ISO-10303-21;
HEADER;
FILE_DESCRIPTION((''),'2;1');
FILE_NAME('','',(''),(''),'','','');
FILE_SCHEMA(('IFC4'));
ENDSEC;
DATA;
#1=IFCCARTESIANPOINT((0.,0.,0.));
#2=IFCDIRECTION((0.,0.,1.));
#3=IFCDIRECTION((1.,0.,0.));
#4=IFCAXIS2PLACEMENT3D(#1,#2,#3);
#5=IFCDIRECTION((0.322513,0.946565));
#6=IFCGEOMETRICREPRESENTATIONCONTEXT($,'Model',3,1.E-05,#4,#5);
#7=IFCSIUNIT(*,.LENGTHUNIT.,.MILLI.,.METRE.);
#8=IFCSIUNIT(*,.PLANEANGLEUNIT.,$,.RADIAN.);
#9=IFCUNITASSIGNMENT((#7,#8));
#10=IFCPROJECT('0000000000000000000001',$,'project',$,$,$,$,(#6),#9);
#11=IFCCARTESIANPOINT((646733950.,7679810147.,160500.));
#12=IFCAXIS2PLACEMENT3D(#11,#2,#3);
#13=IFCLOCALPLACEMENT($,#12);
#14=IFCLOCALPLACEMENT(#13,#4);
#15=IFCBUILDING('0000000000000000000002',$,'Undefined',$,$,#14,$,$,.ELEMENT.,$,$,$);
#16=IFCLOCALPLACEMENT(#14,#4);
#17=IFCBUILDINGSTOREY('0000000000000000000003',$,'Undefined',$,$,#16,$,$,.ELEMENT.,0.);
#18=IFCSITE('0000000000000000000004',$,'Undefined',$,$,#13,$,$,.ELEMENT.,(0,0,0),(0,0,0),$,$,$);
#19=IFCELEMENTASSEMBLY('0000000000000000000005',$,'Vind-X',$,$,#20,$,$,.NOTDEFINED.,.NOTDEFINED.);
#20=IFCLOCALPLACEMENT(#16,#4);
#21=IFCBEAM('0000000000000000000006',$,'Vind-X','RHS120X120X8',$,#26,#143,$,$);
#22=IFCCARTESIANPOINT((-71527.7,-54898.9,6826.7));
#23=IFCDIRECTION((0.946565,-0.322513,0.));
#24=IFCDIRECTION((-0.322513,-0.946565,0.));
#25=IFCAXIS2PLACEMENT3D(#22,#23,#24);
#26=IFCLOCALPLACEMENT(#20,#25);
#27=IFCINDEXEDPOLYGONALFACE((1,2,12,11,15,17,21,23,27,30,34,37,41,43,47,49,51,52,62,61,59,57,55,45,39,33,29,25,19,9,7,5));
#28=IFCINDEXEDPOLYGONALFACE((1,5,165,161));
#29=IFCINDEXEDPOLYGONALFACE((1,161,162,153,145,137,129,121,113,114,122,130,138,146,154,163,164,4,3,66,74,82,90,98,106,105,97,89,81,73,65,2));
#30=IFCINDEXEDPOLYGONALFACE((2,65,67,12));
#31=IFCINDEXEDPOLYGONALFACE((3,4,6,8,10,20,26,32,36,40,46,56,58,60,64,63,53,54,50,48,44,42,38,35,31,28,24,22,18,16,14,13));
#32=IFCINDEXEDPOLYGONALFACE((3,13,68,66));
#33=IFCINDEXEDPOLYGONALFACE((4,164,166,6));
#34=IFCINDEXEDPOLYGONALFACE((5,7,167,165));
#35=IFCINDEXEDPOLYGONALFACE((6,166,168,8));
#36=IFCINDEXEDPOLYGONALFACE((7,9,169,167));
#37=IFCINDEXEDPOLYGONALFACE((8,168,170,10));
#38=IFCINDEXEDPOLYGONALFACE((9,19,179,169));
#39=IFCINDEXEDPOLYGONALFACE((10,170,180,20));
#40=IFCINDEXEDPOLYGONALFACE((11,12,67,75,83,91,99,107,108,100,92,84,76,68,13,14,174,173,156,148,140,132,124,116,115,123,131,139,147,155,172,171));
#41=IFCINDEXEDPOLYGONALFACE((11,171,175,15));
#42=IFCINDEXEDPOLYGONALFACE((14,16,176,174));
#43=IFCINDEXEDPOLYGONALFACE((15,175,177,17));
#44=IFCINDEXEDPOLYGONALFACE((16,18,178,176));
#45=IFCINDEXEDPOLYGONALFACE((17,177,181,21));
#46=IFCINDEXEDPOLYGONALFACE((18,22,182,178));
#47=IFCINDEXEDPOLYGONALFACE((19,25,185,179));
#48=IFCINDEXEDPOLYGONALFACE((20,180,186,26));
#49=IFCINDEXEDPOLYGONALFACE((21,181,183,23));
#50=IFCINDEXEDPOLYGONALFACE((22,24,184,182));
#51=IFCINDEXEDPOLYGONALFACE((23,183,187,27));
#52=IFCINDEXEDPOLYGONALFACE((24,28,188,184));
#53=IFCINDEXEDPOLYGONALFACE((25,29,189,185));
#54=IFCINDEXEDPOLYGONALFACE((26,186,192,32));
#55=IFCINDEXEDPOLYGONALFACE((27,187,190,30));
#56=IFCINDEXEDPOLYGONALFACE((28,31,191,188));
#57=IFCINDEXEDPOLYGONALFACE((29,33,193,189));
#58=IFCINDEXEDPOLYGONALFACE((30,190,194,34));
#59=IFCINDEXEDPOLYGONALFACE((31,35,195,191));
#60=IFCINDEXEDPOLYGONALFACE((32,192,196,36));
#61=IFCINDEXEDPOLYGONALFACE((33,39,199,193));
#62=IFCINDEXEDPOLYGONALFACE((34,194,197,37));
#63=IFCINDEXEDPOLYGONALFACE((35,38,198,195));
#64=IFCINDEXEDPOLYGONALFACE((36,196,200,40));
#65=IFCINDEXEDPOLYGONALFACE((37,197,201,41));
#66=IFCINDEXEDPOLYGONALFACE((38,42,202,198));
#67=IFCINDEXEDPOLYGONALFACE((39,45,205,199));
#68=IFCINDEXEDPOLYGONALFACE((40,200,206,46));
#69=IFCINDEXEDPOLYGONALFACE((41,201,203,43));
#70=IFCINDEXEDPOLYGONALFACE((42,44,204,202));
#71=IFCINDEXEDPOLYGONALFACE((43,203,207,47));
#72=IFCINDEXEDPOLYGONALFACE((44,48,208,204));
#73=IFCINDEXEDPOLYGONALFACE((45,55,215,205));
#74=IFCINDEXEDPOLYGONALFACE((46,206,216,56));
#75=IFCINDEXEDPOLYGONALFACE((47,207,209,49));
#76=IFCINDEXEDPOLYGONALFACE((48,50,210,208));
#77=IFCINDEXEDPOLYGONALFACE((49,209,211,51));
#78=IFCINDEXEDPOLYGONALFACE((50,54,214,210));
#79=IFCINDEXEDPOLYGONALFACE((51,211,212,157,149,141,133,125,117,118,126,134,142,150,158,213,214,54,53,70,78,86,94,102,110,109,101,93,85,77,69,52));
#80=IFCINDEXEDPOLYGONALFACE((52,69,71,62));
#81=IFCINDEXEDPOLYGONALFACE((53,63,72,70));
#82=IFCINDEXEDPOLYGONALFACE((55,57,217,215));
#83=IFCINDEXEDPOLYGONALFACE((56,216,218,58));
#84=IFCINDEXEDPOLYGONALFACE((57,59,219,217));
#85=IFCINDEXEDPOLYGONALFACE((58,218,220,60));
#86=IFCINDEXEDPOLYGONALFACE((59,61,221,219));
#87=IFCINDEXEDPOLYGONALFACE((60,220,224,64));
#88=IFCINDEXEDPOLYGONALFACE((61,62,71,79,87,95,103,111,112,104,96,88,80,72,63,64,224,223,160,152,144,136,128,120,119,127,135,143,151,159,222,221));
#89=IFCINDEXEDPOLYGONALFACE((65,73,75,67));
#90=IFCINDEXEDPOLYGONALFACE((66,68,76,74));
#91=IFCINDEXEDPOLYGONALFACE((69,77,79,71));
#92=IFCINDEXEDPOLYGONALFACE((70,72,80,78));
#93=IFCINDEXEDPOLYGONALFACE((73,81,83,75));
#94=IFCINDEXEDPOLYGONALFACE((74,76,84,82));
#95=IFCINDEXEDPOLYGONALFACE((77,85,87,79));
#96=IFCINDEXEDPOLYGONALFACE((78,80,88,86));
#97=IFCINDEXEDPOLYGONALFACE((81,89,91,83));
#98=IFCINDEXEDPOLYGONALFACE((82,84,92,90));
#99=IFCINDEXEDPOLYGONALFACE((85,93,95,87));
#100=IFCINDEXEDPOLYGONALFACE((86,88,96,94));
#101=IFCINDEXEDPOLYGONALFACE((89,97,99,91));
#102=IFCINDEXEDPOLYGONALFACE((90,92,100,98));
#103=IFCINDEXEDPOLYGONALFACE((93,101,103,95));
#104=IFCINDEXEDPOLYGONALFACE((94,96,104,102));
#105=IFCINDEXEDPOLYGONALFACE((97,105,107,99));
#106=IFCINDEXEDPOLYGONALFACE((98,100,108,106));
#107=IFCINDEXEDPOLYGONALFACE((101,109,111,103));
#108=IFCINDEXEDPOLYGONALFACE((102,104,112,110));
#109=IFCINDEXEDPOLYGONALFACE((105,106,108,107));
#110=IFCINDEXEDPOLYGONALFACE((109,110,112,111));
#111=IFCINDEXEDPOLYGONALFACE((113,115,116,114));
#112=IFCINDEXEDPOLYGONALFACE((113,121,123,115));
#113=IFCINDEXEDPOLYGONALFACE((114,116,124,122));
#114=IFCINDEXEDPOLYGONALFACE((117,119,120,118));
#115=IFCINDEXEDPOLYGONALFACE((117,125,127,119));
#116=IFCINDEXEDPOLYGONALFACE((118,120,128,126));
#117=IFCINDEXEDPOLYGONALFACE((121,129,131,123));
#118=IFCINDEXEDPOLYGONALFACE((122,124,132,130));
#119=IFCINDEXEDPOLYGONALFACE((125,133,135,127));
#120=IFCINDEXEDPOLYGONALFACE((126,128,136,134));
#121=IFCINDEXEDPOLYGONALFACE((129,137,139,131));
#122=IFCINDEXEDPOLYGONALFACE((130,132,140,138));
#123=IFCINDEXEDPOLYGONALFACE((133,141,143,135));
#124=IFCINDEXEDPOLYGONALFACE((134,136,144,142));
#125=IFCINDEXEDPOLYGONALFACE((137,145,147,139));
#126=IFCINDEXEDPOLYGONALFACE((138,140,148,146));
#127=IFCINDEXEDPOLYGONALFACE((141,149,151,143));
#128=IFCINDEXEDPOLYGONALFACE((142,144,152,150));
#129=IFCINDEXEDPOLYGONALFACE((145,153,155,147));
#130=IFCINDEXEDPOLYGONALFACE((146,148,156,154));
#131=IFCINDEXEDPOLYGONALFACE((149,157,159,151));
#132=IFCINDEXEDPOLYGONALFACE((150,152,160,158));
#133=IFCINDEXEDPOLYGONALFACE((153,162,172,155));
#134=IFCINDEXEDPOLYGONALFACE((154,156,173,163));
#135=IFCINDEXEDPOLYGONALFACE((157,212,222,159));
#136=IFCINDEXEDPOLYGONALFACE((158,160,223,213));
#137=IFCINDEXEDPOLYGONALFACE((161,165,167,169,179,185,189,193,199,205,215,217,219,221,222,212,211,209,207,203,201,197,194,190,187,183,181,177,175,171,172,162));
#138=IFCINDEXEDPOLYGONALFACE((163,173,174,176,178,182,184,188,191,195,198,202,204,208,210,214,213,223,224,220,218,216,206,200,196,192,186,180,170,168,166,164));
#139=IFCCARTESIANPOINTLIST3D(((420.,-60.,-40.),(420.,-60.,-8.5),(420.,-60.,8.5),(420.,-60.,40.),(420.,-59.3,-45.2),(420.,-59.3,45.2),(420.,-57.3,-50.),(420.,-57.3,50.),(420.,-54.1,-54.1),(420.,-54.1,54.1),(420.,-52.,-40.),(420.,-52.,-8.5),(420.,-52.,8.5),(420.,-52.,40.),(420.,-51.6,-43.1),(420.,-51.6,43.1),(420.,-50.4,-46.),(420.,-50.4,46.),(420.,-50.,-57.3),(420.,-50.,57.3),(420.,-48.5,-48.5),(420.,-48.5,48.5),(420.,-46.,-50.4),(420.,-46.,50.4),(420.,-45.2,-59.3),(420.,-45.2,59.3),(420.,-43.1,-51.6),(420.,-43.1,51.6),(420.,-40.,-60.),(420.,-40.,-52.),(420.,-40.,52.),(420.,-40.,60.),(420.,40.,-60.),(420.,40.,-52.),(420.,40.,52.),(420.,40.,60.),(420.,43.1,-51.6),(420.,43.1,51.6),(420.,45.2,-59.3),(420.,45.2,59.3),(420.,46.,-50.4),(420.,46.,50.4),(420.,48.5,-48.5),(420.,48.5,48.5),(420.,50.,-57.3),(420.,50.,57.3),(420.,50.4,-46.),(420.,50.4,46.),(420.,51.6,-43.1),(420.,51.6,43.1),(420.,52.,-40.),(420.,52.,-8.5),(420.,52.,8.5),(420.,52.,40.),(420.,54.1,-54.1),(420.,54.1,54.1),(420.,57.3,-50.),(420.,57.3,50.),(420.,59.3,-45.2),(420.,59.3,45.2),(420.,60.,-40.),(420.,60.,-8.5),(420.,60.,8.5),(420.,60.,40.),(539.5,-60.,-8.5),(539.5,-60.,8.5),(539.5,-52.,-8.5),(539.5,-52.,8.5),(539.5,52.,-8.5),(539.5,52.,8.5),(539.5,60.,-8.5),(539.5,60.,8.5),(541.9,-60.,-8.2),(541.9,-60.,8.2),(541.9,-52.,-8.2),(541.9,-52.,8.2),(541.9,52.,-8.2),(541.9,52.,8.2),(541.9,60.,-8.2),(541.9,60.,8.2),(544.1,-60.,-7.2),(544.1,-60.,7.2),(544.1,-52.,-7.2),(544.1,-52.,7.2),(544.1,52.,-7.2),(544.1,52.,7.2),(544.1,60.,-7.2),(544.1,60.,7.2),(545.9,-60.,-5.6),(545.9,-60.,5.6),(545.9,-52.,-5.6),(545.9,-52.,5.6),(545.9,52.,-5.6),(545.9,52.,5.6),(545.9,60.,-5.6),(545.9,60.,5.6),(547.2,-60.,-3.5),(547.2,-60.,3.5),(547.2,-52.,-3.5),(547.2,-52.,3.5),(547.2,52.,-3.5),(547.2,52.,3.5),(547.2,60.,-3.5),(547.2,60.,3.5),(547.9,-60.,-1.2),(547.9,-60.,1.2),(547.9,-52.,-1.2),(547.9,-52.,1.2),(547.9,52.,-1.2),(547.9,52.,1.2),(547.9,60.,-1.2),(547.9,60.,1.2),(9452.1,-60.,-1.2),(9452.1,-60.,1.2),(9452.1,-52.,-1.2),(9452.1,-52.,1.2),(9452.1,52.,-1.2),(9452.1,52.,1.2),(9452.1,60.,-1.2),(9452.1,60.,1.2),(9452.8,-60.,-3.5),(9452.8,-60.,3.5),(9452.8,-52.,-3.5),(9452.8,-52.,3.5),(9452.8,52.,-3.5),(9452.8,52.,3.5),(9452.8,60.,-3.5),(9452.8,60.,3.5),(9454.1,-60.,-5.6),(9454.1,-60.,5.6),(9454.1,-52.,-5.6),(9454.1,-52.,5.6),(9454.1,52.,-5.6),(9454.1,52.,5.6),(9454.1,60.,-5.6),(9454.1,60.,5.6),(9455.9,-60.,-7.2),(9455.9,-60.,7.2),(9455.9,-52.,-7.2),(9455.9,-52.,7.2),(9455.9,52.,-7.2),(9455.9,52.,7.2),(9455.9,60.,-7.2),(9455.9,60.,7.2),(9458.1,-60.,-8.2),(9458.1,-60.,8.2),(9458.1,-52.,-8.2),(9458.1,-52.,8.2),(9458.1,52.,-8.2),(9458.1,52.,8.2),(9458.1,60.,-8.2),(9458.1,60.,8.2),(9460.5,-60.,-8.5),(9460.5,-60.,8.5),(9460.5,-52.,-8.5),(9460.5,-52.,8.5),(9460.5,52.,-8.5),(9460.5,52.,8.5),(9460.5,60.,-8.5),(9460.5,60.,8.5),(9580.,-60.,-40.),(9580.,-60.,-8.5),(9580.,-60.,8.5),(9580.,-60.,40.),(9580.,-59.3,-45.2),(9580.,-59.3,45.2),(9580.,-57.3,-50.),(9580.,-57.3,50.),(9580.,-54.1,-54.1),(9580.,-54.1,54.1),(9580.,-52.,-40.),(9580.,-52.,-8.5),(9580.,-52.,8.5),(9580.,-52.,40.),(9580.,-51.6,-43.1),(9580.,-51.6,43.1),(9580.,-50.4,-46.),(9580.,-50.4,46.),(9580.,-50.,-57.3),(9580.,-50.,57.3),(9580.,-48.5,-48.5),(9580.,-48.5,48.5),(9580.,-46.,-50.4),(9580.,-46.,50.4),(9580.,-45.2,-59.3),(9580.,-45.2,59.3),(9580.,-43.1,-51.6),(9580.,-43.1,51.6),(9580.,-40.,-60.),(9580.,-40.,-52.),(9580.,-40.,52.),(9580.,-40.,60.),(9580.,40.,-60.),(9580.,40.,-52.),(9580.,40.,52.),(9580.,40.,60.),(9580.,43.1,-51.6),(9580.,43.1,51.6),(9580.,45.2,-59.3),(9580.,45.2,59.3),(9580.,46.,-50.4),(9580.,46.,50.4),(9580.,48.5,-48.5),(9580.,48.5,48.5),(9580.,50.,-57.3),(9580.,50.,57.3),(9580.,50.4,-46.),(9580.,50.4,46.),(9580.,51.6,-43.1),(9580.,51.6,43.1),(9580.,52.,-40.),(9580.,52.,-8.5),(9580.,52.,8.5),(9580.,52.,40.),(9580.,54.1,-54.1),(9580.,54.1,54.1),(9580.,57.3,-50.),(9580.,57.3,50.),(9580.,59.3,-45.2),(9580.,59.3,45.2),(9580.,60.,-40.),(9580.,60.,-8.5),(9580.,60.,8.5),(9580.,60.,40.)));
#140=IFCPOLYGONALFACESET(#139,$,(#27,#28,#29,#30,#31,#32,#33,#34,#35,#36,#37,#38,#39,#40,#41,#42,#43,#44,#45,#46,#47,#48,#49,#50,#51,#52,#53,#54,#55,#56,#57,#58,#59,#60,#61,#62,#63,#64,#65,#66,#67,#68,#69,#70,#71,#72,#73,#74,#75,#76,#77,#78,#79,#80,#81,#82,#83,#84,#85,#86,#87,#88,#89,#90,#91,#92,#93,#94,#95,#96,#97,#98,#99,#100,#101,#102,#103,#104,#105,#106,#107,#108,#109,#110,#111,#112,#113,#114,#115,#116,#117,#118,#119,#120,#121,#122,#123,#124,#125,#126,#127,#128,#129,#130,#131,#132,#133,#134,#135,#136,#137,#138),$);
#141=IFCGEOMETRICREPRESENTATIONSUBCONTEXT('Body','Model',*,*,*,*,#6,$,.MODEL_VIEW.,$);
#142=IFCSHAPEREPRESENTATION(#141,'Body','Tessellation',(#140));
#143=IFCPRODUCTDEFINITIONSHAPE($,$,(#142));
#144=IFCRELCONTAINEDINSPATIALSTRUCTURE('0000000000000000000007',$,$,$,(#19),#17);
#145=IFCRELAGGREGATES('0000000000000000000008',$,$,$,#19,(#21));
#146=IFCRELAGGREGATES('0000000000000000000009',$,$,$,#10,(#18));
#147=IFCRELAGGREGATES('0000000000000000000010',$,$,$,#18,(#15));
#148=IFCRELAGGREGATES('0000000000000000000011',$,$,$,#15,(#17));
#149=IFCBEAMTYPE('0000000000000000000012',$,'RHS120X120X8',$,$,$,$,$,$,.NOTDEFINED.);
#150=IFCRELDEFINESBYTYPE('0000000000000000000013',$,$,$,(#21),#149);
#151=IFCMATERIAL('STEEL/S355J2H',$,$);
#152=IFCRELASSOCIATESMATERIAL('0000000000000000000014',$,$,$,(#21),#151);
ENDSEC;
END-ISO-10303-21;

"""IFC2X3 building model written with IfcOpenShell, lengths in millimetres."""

from ifc_helpers import new_model, si_unit, direction, frame, frame_2d, origin_with_axes, origin_2d_with_axis, place, context, subcontext, project, spatial, polyline, circle_curve, parameter, trimmed, segment, composite_curve, hollow_rectangle, outline, extrude, boolean, halfspace, material, type_object, element, aggregate, save


model = new_model("IFC2X3")

# Units and contexts
model_context = context("Model", 3, precision=1e-05, world=origin_with_axes(), true_north=direction((0.322513, 0.946565)))
body_context = subcontext(model_context, "Body", "Model", "MODEL_VIEW")
ifc_project = project(units=[si_unit("LENGTHUNIT", "METRE", prefix="MILLI"), si_unit("PLANEANGLEUNIT", "RADIAN")], contexts=[model_context])

# Site, building, storey
site_placement = place(None, frame((646733950.0, 7679810147.0, 160500.0), z_axis=(0.0, 0.0, 1.0), x_axis=(1.0, 0.0, 0.0)))
site = spatial("IfcSite", under=ifc_project, at=site_placement, Name="Undefined", CompositionType="ELEMENT", RefLatitude=(0, 0, 0), RefLongitude=(0, 0, 0))
building_placement = place(site_placement, origin_with_axes())
building = spatial("IfcBuilding", under=site, at=building_placement, Name="Undefined", CompositionType="ELEMENT")
storey_placement = place(building_placement, origin_with_axes())
storey = spatial("IfcBuildingStorey", under=building, at=storey_placement, Name="Undefined", CompositionType="ELEMENT", Elevation=0.0)

# Element assembly, beam
ifc_material_1 = material(Name="STEEL/S355J2H")
assembly_1_placement = place(storey_placement, origin_with_axes())
assembly_1 = element("IfcElementAssembly", 1, at=assembly_1_placement, inside=storey, Name="Vind-X", AssemblyPlace="NOTDEFINED", PredefinedType="NOTDEFINED")
beam_type_1 = type_object("IfcBeamType", Name="RHS120X120X8", PredefinedType="NOTDEFINED")
beam_1_placement = place(assembly_1_placement, frame((-71527.7, -54898.9, 6826.7), z_axis=(0.946565, -0.322513, 0.0), x_axis=(-0.322513, -0.946565, 0.0)))
beam_1 = element("IfcBeam", 2, at=beam_1_placement, type_object=beam_type_1, material=ifc_material_1, Name="Vind-X", Description="RHS120X120X8", context=body_context, shape_type="CSG", body=[
    boolean("DIFFERENCE", boolean("DIFFERENCE", boolean("DIFFERENCE", boolean("DIFFERENCE", extrude(hollow_rectangle(XDim=120.0, YDim=120.0, WallThickness=8.0, InnerFilletRadius=12.0, OuterFilletRadius=20.0, at=origin_2d_with_axis()), frame((10000.0, 0.0, 0.0), z_axis=(-1.0, 0.0, 0.0), x_axis=(0.0, -1.0, 0.0)), (0.0, 0.0, 1.0), 10000.0), extrude(outline(composite_curve([segment(trimmed(circle_curve(frame_2d((8.5, 8.5), x_axis=(-1.0, 0.0)), 8.5), [parameter(0.0)], [parameter(1.570796)], True, "PARAMETER"), True, "CONTINUOUS"), segment(polyline([(8.5, 0.0), (133.0, 0.0), (133.0, 17.0), (8.5, 17.0)]), True, "CONTINUOUS"), segment(trimmed(circle_curve(frame_2d((8.5, 8.5), x_axis=(0.0, 1.0)), 8.5), [parameter(0.0)], [parameter(1.570796)], True, "PARAMETER"), True, "CONTINUOUS"), segment(polyline([(0.0, 8.5), (0.0, 8.5)]), True, "CONTINUOUS")], self_intersect=True)), frame((548.0, 62.2, 8.5), z_axis=(0.0, -1.0, 0.0), x_axis=(-1.0, 0.0, 0.0)), (0.0, 0.0, 1.0), 124.5)), extrude(outline(composite_curve([segment(trimmed(circle_curve(frame_2d((8.5, 8.5), x_axis=(-1.0, 0.0)), 8.5), [parameter(0.0)], [parameter(1.570796)], True, "PARAMETER"), True, "CONTINUOUS"), segment(polyline([(8.5, 0.0), (133.0, 0.0), (133.0, 17.0), (8.5, 17.0)]), True, "CONTINUOUS"), segment(trimmed(circle_curve(frame_2d((8.5, 8.5), x_axis=(0.0, 1.0)), 8.5), [parameter(0.0)], [parameter(1.570796)], True, "PARAMETER"), True, "CONTINUOUS"), segment(polyline([(0.0, 8.5), (0.0, 8.5)]), True, "CONTINUOUS")], self_intersect=True)), frame((9452.0, -62.2, 8.5), z_axis=(0.0, 1.0, 0.0), x_axis=(1.0, 0.0, 0.0)), (0.0, 0.0, 1.0), 124.5)), halfspace(frame((9580.0, 0.0, -1000.0), z_axis=(-1.0, 0.0, 0.0), x_axis=(0.0, 1.0, 0.0)), True)), halfspace(frame((420.0, 0.0, -1000.0), z_axis=(1.0, 0.0, 0.0), x_axis=(0.0, -1.0, 0.0)), True)),
])

aggregate(assembly_1, [beam_1])

save(model, "model.ifc")
